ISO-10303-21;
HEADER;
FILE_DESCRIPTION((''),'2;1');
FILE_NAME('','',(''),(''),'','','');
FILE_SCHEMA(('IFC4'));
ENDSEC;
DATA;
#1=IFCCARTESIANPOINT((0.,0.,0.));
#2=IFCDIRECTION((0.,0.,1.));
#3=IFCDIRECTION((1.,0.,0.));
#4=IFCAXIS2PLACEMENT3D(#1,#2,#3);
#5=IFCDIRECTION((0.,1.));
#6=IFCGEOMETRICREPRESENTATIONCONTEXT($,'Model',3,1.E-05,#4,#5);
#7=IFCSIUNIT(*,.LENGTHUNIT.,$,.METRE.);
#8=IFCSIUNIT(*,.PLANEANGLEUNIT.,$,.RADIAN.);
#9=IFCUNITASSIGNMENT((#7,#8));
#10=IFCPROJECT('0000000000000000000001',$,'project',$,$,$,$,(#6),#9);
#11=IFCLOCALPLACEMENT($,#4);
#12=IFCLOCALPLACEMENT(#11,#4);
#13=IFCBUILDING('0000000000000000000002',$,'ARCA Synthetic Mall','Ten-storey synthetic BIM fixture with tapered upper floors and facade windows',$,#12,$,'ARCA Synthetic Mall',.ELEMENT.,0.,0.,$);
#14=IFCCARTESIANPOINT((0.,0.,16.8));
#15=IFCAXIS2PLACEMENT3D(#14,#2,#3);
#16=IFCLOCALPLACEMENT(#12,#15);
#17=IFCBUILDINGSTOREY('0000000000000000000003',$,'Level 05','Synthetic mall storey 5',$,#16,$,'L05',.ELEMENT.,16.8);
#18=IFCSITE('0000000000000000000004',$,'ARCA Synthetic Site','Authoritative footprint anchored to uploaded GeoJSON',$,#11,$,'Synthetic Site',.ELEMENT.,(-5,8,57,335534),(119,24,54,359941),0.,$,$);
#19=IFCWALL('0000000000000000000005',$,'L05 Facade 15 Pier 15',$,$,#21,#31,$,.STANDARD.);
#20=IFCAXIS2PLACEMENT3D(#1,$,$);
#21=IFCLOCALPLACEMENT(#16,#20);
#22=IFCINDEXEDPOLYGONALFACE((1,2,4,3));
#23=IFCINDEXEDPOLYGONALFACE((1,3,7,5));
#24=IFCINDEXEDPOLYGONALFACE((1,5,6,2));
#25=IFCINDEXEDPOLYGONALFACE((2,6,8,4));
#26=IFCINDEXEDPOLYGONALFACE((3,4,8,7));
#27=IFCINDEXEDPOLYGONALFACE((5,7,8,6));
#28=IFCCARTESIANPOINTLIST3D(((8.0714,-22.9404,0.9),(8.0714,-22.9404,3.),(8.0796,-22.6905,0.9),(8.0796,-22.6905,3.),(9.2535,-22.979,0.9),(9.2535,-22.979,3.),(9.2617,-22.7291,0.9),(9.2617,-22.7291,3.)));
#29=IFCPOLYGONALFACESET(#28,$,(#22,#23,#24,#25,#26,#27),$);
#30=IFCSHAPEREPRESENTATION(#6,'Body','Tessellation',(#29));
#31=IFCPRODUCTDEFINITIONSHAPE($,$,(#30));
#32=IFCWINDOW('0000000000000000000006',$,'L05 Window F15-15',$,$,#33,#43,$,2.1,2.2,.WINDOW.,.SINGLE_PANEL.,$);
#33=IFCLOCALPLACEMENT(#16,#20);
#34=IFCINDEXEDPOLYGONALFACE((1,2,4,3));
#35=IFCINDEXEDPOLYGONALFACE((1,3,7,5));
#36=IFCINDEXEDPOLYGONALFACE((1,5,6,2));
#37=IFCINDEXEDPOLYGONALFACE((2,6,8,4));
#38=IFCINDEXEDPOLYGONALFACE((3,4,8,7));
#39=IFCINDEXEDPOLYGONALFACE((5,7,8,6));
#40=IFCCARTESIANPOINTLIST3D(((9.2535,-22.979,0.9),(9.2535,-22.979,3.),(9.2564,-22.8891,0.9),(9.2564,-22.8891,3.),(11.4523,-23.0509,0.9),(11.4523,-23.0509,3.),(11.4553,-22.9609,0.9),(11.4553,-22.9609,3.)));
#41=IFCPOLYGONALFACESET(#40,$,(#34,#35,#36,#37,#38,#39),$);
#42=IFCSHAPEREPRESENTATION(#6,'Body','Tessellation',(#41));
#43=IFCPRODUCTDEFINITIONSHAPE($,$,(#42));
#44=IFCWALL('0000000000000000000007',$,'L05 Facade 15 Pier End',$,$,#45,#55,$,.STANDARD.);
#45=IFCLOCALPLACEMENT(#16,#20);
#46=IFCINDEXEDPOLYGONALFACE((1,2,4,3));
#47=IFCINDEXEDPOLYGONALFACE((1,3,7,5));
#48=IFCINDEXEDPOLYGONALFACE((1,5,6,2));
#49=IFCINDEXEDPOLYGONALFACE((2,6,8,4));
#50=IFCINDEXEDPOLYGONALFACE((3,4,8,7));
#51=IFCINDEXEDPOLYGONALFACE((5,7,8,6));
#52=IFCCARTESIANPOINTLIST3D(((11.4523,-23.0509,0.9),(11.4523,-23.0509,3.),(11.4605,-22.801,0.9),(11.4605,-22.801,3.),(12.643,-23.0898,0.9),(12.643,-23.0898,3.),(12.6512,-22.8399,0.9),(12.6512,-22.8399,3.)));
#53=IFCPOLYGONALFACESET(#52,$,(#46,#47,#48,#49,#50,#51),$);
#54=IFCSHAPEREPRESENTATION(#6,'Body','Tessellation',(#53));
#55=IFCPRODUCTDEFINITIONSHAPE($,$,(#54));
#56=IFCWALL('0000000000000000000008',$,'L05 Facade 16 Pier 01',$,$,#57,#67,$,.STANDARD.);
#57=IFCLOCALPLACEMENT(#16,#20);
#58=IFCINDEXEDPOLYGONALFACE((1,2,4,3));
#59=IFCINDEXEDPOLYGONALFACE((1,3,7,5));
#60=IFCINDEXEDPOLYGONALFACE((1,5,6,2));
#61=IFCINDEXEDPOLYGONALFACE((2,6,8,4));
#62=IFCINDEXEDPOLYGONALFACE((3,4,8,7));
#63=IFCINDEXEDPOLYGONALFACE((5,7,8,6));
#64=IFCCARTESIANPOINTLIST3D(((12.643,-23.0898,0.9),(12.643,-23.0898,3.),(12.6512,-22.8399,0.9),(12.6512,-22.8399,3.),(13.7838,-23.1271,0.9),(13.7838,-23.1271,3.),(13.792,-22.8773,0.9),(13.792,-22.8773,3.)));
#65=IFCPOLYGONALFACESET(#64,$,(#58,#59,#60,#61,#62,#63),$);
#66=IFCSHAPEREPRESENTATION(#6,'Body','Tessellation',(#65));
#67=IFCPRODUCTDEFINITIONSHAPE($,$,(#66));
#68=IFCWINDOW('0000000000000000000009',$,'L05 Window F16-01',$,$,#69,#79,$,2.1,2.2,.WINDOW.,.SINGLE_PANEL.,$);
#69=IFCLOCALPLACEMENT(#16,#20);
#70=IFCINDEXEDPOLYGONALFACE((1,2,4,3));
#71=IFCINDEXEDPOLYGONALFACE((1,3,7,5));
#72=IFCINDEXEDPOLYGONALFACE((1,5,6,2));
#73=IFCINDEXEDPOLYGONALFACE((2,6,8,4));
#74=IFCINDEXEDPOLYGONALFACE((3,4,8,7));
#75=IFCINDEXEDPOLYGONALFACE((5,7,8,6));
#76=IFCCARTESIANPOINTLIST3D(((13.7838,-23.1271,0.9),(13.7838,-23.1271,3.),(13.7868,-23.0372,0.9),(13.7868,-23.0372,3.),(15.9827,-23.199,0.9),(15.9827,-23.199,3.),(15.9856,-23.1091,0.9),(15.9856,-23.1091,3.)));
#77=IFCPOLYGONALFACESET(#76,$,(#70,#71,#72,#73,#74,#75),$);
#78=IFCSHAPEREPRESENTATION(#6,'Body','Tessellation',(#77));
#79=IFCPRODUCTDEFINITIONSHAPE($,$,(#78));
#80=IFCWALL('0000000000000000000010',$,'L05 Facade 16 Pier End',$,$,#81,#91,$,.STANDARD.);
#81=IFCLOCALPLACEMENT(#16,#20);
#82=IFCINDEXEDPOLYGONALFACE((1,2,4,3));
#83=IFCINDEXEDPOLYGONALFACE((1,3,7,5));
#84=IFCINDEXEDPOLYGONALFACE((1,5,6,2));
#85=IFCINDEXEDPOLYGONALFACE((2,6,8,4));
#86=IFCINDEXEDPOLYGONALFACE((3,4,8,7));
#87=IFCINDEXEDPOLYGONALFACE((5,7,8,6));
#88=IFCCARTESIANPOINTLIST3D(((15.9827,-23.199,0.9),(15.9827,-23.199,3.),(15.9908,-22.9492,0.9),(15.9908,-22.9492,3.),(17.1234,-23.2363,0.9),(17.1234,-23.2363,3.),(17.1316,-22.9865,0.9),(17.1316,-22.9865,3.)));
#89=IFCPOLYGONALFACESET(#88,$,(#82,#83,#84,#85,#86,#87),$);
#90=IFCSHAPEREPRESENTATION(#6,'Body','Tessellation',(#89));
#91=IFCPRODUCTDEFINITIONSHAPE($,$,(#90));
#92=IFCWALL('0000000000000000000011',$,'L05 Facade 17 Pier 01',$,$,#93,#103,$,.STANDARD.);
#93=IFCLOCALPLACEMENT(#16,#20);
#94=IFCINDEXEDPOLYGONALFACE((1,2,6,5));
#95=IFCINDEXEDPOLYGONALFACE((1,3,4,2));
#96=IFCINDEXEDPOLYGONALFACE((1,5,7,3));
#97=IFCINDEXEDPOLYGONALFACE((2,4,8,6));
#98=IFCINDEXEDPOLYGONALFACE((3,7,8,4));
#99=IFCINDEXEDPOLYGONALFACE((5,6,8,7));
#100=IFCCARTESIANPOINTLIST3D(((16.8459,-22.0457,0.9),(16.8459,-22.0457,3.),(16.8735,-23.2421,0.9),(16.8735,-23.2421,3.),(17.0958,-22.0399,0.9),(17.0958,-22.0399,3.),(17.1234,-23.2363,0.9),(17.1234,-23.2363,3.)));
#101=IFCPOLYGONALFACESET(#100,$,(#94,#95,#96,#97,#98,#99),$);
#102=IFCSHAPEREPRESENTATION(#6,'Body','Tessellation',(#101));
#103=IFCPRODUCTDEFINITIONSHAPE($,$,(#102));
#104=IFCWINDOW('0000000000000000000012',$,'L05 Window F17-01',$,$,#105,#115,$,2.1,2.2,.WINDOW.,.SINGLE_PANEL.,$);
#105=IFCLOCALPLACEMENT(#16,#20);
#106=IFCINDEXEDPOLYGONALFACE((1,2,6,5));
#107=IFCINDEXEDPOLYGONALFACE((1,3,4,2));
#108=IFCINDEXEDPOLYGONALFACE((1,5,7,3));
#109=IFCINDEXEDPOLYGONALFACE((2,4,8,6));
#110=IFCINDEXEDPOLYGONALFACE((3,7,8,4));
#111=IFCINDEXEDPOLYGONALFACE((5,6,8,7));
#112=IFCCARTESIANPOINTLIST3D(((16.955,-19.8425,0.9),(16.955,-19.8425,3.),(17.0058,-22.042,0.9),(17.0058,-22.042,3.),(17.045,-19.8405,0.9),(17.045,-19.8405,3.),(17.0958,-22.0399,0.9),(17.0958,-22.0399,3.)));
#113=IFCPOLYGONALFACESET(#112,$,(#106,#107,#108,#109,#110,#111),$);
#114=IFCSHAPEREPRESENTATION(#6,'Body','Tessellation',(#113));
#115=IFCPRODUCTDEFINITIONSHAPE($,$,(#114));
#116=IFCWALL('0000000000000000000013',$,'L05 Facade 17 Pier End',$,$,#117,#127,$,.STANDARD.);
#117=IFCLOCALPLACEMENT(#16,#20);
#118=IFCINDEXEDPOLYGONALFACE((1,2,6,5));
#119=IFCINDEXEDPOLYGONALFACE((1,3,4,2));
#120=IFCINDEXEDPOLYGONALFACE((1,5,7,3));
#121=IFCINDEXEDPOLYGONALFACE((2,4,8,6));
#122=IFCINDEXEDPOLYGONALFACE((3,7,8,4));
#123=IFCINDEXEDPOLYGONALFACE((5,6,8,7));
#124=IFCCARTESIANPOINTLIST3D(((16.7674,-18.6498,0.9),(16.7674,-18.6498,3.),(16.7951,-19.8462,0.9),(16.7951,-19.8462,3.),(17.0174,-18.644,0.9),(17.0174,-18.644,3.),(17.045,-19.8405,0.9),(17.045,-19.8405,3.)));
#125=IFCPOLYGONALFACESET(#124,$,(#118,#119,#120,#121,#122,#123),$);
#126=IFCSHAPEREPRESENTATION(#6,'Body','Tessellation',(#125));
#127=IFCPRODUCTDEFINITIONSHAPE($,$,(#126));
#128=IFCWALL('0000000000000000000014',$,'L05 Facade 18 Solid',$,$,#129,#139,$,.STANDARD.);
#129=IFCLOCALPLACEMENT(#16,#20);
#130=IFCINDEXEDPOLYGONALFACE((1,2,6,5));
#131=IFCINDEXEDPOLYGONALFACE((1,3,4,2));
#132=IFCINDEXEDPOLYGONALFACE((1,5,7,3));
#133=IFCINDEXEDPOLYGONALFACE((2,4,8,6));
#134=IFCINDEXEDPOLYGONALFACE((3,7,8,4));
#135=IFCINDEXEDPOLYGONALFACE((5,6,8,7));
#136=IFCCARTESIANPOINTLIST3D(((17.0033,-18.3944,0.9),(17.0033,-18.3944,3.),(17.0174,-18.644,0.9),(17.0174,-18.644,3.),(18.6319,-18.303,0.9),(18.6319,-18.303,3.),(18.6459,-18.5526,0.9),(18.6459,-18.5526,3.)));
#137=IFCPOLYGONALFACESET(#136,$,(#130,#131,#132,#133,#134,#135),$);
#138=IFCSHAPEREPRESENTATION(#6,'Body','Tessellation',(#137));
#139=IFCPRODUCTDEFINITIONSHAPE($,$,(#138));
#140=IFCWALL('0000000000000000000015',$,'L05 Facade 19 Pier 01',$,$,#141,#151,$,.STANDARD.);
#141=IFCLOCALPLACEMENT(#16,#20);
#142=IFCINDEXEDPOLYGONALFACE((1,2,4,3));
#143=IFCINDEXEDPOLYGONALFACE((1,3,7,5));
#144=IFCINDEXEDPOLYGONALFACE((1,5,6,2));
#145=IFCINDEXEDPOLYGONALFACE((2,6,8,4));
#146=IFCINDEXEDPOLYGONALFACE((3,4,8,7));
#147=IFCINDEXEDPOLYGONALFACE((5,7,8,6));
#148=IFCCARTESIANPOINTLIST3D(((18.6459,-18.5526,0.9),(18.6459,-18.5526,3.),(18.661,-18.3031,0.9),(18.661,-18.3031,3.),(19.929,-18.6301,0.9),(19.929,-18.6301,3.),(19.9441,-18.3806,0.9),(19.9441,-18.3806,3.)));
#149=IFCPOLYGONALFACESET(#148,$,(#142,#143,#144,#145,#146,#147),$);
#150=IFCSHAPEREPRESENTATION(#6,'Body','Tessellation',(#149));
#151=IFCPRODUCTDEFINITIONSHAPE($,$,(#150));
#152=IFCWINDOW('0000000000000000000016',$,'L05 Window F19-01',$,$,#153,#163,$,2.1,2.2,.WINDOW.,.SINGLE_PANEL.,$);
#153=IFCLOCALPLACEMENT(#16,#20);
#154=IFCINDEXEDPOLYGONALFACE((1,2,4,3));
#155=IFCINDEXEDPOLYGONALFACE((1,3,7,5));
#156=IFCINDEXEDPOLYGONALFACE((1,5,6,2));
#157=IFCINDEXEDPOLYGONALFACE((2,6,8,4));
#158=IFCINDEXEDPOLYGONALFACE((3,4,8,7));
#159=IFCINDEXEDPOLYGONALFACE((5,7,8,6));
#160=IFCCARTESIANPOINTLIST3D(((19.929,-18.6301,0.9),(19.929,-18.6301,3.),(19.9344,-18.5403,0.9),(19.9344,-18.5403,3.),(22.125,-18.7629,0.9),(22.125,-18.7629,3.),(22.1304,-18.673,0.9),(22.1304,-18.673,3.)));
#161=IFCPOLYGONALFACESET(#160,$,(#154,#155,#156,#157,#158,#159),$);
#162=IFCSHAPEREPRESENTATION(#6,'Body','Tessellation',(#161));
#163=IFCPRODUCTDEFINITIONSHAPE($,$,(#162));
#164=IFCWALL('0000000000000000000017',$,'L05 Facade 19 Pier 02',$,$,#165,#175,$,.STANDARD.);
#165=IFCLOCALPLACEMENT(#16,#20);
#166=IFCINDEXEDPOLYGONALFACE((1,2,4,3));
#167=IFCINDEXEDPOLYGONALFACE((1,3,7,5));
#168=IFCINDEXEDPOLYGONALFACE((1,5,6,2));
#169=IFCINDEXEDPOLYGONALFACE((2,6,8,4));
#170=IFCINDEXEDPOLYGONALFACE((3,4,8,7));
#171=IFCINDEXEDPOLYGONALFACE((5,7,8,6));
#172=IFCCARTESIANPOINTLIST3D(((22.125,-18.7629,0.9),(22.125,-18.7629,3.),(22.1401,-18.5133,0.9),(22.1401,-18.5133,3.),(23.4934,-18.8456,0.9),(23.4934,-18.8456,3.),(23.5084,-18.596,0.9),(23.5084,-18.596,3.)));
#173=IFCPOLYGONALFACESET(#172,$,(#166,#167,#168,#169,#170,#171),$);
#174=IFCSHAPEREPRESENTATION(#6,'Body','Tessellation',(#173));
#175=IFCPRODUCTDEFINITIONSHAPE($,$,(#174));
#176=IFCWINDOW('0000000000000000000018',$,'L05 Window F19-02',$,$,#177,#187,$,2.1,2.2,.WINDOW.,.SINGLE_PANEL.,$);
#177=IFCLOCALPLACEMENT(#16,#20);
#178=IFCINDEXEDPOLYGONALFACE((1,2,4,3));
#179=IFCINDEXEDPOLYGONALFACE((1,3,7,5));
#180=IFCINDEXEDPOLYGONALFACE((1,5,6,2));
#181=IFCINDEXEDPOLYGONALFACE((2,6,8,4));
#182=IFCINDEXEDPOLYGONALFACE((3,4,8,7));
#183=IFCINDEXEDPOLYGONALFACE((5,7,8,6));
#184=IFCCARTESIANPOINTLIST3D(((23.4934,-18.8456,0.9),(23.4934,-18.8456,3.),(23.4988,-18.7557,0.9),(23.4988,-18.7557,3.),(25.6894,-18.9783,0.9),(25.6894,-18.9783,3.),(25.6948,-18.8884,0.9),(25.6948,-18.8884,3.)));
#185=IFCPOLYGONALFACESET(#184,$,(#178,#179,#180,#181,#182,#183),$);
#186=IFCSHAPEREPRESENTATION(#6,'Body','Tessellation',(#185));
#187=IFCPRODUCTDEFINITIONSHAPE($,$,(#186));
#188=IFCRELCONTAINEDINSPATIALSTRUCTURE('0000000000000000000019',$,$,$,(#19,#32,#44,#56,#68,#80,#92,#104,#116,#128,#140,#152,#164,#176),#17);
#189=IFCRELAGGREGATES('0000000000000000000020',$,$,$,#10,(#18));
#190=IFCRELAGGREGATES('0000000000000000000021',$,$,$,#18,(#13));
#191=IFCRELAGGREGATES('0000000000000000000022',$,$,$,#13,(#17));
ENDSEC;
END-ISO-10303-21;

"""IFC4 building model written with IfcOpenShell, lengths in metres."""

from ifc_helpers import new_model, si_unit, direction, frame, origin_with_axes, place, context, project, spatial, polyline, outline, extrude, element, save


model = new_model("IFC4")

# Units and contexts
model_context = context("Model", 3, precision=1e-05, world=origin_with_axes(), true_north=direction((0.0, 1.0)))
ifc_project = project(units=[si_unit("LENGTHUNIT", "METRE"), si_unit("PLANEANGLEUNIT", "RADIAN")], contexts=[model_context])

# Site, building, storey
site_placement = place(None, origin_with_axes())
site = spatial("IfcSite", under=ifc_project, at=site_placement, Name="ARCA Synthetic Site", Description="Authoritative footprint anchored to uploaded GeoJSON", LongName="Synthetic Site", CompositionType="ELEMENT", RefLatitude=(-5, 8, 57, 335534), RefLongitude=(119, 24, 54, 359941), RefElevation=0.0)
building_placement = place(site_placement, origin_with_axes())
building = spatial("IfcBuilding", under=site, at=building_placement, Name="ARCA Synthetic Mall", Description="Ten-storey synthetic BIM fixture with tapered upper floors and facade windows", LongName="ARCA Synthetic Mall", CompositionType="ELEMENT", ElevationOfRefHeight=0.0, ElevationOfTerrain=0.0)
storey_placement = place(building_placement, frame((0.0, 0.0, 16.8), z_axis=(0.0, 0.0, 1.0), x_axis=(1.0, 0.0, 0.0)))
storey = spatial("IfcBuildingStorey", under=building, at=storey_placement, Name="Level 05", Description="Synthetic mall storey 5", LongName="L05", CompositionType="ELEMENT", Elevation=16.8)

# Wall
wall_1_placement = place(storey_placement, frame((0.0, 0.0, 0.9), z_axis=(0.0, 0.0, 1.0), x_axis=(1.0, 0.0, 0.0)))
element("IfcWall", 1, at=wall_1_placement, inside=storey, Name="L05 Facade 15 Pier 15", PredefinedType="STANDARD", context=model_context, shape_type="SweptSolid", body=[
    extrude(outline(polyline([(8.0714, -22.9404), (9.2535, -22.979), (9.2617, -22.7291), (8.0796, -22.6905), (8.0714, -22.9404)])), origin_with_axes(), (0.0, 0.0, 1.0), 2.1),
])

# Window
window_1_placement = place(storey_placement, frame((0.0, 0.0, 0.9), z_axis=(0.0, 0.0, 1.0), x_axis=(1.0, 0.0, 0.0)))
element("IfcWindow", 2, at=window_1_placement, inside=storey, Name="L05 Window F15-15", OverallHeight=2.1, OverallWidth=2.2, PartitioningType="SINGLE_PANEL", PredefinedType="WINDOW", context=model_context, shape_type="SweptSolid", body=[
    extrude(outline(polyline([(9.2535, -22.979), (11.4523, -23.0509), (11.4553, -22.9609), (9.2564, -22.8891), (9.2535, -22.979)])), origin_with_axes(), (0.0, 0.0, 1.0), 2.1),
])

# Walls
wall_2_placement = place(storey_placement, frame((0.0, 0.0, 0.9), z_axis=(0.0, 0.0, 1.0), x_axis=(1.0, 0.0, 0.0)))
element("IfcWall", 3, at=wall_2_placement, inside=storey, Name="L05 Facade 15 Pier End", PredefinedType="STANDARD", context=model_context, shape_type="SweptSolid", body=[
    extrude(outline(polyline([(11.4523, -23.0509), (12.6431, -23.0898), (12.6512, -22.8399), (11.4605, -22.801), (11.4523, -23.0509)])), origin_with_axes(), (0.0, 0.0, 1.0), 2.1),
])
wall_3_placement = place(storey_placement, frame((0.0, 0.0, 0.9), z_axis=(0.0, 0.0, 1.0), x_axis=(1.0, 0.0, 0.0)))
element("IfcWall", 4, at=wall_3_placement, inside=storey, Name="L05 Facade 16 Pier 01", PredefinedType="STANDARD", context=model_context, shape_type="SweptSolid", body=[
    extrude(outline(polyline([(12.6431, -23.0898), (13.7838, -23.1271), (13.792, -22.8773), (12.6512, -22.8399), (12.6431, -23.0898)])), origin_with_axes(), (0.0, 0.0, 1.0), 2.1),
])

# Window
window_2_placement = place(storey_placement, frame((0.0, 0.0, 0.9), z_axis=(0.0, 0.0, 1.0), x_axis=(1.0, 0.0, 0.0)))
element("IfcWindow", 5, at=window_2_placement, inside=storey, Name="L05 Window F16-01", OverallHeight=2.1, OverallWidth=2.2, PartitioningType="SINGLE_PANEL", PredefinedType="WINDOW", context=model_context, shape_type="SweptSolid", body=[
    extrude(outline(polyline([(13.7838, -23.1271), (15.9827, -23.199), (15.9856, -23.1091), (13.7868, -23.0372), (13.7838, -23.1271)])), origin_with_axes(), (0.0, 0.0, 1.0), 2.1),
])

# Walls
wall_4_placement = place(storey_placement, frame((0.0, 0.0, 0.9), z_axis=(0.0, 0.0, 1.0), x_axis=(1.0, 0.0, 0.0)))
element("IfcWall", 6, at=wall_4_placement, inside=storey, Name="L05 Facade 16 Pier End", PredefinedType="STANDARD", context=model_context, shape_type="SweptSolid", body=[
    extrude(outline(polyline([(15.9827, -23.199), (17.1234, -23.2363), (17.1316, -22.9865), (15.9908, -22.9492), (15.9827, -23.199)])), origin_with_axes(), (0.0, 0.0, 1.0), 2.1),
])
wall_5_placement = place(storey_placement, frame((0.0, 0.0, 0.9), z_axis=(0.0, 0.0, 1.0), x_axis=(1.0, 0.0, 0.0)))
element("IfcWall", 7, at=wall_5_placement, inside=storey, Name="L05 Facade 17 Pier 01", PredefinedType="STANDARD", context=model_context, shape_type="SweptSolid", body=[
    extrude(outline(polyline([(17.1234, -23.2363), (17.0958, -22.0399), (16.8459, -22.0457), (16.8735, -23.2421), (17.1234, -23.2363)])), origin_with_axes(), (0.0, 0.0, 1.0), 2.1),
])

# Window
window_3_placement = place(storey_placement, frame((0.0, 0.0, 0.9), z_axis=(0.0, 0.0, 1.0), x_axis=(1.0, 0.0, 0.0)))
element("IfcWindow", 8, at=window_3_placement, inside=storey, Name="L05 Window F17-01", OverallHeight=2.1, OverallWidth=2.2, PartitioningType="SINGLE_PANEL", PredefinedType="WINDOW", context=model_context, shape_type="SweptSolid", body=[
    extrude(outline(polyline([(17.0958, -22.0399), (17.045, -19.8405), (16.955, -19.8425), (17.0058, -22.042), (17.0958, -22.0399)])), origin_with_axes(), (0.0, 0.0, 1.0), 2.1),
])

# Walls
wall_6_placement = place(storey_placement, frame((0.0, 0.0, 0.9), z_axis=(0.0, 0.0, 1.0), x_axis=(1.0, 0.0, 0.0)))
element("IfcWall", 9, at=wall_6_placement, inside=storey, Name="L05 Facade 17 Pier End", PredefinedType="STANDARD", context=model_context, shape_type="SweptSolid", body=[
    extrude(outline(polyline([(17.045, -19.8405), (17.0174, -18.644), (16.7674, -18.6498), (16.7951, -19.8462), (17.045, -19.8405)])), origin_with_axes(), (0.0, 0.0, 1.0), 2.1),
])
wall_7_placement = place(storey_placement, frame((0.0, 0.0, 0.9), z_axis=(0.0, 0.0, 1.0), x_axis=(1.0, 0.0, 0.0)))
element("IfcWall", 10, at=wall_7_placement, inside=storey, Name="L05 Facade 18 Solid", PredefinedType="STANDARD", context=model_context, shape_type="SweptSolid", body=[
    extrude(outline(polyline([(17.0174, -18.644), (18.6459, -18.5526), (18.6319, -18.303), (17.0033, -18.3944), (17.0174, -18.644)])), origin_with_axes(), (0.0, 0.0, 1.0), 2.1),
])
wall_8_placement = place(storey_placement, frame((0.0, 0.0, 0.9), z_axis=(0.0, 0.0, 1.0), x_axis=(1.0, 0.0, 0.0)))
element("IfcWall", 11, at=wall_8_placement, inside=storey, Name="L05 Facade 19 Pier 01", PredefinedType="STANDARD", context=model_context, shape_type="SweptSolid", body=[
    extrude(outline(polyline([(18.6459, -18.5526), (19.929, -18.6301), (19.9441, -18.3806), (18.661, -18.3031), (18.6459, -18.5526)])), origin_with_axes(), (0.0, 0.0, 1.0), 2.1),
])

# Window
window_4_placement = place(storey_placement, frame((0.0, 0.0, 0.9), z_axis=(0.0, 0.0, 1.0), x_axis=(1.0, 0.0, 0.0)))
element("IfcWindow", 12, at=window_4_placement, inside=storey, Name="L05 Window F19-01", OverallHeight=2.1, OverallWidth=2.2, PartitioningType="SINGLE_PANEL", PredefinedType="WINDOW", context=model_context, shape_type="SweptSolid", body=[
    extrude(outline(polyline([(19.929, -18.6301), (22.125, -18.7629), (22.1304, -18.673), (19.9344, -18.5403), (19.929, -18.6301)])), origin_with_axes(), (0.0, 0.0, 1.0), 2.1),
])

# Wall
wall_9_placement = place(storey_placement, frame((0.0, 0.0, 0.9), z_axis=(0.0, 0.0, 1.0), x_axis=(1.0, 0.0, 0.0)))
element("IfcWall", 13, at=wall_9_placement, inside=storey, Name="L05 Facade 19 Pier 02", PredefinedType="STANDARD", context=model_context, shape_type="SweptSolid", body=[
    extrude(outline(polyline([(22.125, -18.7629), (23.4934, -18.8456), (23.5084, -18.596), (22.1401, -18.5133), (22.125, -18.7629)])), origin_with_axes(), (0.0, 0.0, 1.0), 2.1),
])

# Window
window_5_placement = place(storey_placement, frame((0.0, 0.0, 0.9), z_axis=(0.0, 0.0, 1.0), x_axis=(1.0, 0.0, 0.0)))
element("IfcWindow", 14, at=window_5_placement, inside=storey, Name="L05 Window F19-02", OverallHeight=2.1, OverallWidth=2.2, PartitioningType="SINGLE_PANEL", PredefinedType="WINDOW", context=model_context, shape_type="SweptSolid", body=[
    extrude(outline(polyline([(23.4934, -18.8456), (25.6894, -18.9783), (25.6948, -18.8884), (23.4988, -18.7557), (23.4934, -18.8456)])), origin_with_axes(), (0.0, 0.0, 1.0), 2.1),
])

save(model, "model.ifc")
